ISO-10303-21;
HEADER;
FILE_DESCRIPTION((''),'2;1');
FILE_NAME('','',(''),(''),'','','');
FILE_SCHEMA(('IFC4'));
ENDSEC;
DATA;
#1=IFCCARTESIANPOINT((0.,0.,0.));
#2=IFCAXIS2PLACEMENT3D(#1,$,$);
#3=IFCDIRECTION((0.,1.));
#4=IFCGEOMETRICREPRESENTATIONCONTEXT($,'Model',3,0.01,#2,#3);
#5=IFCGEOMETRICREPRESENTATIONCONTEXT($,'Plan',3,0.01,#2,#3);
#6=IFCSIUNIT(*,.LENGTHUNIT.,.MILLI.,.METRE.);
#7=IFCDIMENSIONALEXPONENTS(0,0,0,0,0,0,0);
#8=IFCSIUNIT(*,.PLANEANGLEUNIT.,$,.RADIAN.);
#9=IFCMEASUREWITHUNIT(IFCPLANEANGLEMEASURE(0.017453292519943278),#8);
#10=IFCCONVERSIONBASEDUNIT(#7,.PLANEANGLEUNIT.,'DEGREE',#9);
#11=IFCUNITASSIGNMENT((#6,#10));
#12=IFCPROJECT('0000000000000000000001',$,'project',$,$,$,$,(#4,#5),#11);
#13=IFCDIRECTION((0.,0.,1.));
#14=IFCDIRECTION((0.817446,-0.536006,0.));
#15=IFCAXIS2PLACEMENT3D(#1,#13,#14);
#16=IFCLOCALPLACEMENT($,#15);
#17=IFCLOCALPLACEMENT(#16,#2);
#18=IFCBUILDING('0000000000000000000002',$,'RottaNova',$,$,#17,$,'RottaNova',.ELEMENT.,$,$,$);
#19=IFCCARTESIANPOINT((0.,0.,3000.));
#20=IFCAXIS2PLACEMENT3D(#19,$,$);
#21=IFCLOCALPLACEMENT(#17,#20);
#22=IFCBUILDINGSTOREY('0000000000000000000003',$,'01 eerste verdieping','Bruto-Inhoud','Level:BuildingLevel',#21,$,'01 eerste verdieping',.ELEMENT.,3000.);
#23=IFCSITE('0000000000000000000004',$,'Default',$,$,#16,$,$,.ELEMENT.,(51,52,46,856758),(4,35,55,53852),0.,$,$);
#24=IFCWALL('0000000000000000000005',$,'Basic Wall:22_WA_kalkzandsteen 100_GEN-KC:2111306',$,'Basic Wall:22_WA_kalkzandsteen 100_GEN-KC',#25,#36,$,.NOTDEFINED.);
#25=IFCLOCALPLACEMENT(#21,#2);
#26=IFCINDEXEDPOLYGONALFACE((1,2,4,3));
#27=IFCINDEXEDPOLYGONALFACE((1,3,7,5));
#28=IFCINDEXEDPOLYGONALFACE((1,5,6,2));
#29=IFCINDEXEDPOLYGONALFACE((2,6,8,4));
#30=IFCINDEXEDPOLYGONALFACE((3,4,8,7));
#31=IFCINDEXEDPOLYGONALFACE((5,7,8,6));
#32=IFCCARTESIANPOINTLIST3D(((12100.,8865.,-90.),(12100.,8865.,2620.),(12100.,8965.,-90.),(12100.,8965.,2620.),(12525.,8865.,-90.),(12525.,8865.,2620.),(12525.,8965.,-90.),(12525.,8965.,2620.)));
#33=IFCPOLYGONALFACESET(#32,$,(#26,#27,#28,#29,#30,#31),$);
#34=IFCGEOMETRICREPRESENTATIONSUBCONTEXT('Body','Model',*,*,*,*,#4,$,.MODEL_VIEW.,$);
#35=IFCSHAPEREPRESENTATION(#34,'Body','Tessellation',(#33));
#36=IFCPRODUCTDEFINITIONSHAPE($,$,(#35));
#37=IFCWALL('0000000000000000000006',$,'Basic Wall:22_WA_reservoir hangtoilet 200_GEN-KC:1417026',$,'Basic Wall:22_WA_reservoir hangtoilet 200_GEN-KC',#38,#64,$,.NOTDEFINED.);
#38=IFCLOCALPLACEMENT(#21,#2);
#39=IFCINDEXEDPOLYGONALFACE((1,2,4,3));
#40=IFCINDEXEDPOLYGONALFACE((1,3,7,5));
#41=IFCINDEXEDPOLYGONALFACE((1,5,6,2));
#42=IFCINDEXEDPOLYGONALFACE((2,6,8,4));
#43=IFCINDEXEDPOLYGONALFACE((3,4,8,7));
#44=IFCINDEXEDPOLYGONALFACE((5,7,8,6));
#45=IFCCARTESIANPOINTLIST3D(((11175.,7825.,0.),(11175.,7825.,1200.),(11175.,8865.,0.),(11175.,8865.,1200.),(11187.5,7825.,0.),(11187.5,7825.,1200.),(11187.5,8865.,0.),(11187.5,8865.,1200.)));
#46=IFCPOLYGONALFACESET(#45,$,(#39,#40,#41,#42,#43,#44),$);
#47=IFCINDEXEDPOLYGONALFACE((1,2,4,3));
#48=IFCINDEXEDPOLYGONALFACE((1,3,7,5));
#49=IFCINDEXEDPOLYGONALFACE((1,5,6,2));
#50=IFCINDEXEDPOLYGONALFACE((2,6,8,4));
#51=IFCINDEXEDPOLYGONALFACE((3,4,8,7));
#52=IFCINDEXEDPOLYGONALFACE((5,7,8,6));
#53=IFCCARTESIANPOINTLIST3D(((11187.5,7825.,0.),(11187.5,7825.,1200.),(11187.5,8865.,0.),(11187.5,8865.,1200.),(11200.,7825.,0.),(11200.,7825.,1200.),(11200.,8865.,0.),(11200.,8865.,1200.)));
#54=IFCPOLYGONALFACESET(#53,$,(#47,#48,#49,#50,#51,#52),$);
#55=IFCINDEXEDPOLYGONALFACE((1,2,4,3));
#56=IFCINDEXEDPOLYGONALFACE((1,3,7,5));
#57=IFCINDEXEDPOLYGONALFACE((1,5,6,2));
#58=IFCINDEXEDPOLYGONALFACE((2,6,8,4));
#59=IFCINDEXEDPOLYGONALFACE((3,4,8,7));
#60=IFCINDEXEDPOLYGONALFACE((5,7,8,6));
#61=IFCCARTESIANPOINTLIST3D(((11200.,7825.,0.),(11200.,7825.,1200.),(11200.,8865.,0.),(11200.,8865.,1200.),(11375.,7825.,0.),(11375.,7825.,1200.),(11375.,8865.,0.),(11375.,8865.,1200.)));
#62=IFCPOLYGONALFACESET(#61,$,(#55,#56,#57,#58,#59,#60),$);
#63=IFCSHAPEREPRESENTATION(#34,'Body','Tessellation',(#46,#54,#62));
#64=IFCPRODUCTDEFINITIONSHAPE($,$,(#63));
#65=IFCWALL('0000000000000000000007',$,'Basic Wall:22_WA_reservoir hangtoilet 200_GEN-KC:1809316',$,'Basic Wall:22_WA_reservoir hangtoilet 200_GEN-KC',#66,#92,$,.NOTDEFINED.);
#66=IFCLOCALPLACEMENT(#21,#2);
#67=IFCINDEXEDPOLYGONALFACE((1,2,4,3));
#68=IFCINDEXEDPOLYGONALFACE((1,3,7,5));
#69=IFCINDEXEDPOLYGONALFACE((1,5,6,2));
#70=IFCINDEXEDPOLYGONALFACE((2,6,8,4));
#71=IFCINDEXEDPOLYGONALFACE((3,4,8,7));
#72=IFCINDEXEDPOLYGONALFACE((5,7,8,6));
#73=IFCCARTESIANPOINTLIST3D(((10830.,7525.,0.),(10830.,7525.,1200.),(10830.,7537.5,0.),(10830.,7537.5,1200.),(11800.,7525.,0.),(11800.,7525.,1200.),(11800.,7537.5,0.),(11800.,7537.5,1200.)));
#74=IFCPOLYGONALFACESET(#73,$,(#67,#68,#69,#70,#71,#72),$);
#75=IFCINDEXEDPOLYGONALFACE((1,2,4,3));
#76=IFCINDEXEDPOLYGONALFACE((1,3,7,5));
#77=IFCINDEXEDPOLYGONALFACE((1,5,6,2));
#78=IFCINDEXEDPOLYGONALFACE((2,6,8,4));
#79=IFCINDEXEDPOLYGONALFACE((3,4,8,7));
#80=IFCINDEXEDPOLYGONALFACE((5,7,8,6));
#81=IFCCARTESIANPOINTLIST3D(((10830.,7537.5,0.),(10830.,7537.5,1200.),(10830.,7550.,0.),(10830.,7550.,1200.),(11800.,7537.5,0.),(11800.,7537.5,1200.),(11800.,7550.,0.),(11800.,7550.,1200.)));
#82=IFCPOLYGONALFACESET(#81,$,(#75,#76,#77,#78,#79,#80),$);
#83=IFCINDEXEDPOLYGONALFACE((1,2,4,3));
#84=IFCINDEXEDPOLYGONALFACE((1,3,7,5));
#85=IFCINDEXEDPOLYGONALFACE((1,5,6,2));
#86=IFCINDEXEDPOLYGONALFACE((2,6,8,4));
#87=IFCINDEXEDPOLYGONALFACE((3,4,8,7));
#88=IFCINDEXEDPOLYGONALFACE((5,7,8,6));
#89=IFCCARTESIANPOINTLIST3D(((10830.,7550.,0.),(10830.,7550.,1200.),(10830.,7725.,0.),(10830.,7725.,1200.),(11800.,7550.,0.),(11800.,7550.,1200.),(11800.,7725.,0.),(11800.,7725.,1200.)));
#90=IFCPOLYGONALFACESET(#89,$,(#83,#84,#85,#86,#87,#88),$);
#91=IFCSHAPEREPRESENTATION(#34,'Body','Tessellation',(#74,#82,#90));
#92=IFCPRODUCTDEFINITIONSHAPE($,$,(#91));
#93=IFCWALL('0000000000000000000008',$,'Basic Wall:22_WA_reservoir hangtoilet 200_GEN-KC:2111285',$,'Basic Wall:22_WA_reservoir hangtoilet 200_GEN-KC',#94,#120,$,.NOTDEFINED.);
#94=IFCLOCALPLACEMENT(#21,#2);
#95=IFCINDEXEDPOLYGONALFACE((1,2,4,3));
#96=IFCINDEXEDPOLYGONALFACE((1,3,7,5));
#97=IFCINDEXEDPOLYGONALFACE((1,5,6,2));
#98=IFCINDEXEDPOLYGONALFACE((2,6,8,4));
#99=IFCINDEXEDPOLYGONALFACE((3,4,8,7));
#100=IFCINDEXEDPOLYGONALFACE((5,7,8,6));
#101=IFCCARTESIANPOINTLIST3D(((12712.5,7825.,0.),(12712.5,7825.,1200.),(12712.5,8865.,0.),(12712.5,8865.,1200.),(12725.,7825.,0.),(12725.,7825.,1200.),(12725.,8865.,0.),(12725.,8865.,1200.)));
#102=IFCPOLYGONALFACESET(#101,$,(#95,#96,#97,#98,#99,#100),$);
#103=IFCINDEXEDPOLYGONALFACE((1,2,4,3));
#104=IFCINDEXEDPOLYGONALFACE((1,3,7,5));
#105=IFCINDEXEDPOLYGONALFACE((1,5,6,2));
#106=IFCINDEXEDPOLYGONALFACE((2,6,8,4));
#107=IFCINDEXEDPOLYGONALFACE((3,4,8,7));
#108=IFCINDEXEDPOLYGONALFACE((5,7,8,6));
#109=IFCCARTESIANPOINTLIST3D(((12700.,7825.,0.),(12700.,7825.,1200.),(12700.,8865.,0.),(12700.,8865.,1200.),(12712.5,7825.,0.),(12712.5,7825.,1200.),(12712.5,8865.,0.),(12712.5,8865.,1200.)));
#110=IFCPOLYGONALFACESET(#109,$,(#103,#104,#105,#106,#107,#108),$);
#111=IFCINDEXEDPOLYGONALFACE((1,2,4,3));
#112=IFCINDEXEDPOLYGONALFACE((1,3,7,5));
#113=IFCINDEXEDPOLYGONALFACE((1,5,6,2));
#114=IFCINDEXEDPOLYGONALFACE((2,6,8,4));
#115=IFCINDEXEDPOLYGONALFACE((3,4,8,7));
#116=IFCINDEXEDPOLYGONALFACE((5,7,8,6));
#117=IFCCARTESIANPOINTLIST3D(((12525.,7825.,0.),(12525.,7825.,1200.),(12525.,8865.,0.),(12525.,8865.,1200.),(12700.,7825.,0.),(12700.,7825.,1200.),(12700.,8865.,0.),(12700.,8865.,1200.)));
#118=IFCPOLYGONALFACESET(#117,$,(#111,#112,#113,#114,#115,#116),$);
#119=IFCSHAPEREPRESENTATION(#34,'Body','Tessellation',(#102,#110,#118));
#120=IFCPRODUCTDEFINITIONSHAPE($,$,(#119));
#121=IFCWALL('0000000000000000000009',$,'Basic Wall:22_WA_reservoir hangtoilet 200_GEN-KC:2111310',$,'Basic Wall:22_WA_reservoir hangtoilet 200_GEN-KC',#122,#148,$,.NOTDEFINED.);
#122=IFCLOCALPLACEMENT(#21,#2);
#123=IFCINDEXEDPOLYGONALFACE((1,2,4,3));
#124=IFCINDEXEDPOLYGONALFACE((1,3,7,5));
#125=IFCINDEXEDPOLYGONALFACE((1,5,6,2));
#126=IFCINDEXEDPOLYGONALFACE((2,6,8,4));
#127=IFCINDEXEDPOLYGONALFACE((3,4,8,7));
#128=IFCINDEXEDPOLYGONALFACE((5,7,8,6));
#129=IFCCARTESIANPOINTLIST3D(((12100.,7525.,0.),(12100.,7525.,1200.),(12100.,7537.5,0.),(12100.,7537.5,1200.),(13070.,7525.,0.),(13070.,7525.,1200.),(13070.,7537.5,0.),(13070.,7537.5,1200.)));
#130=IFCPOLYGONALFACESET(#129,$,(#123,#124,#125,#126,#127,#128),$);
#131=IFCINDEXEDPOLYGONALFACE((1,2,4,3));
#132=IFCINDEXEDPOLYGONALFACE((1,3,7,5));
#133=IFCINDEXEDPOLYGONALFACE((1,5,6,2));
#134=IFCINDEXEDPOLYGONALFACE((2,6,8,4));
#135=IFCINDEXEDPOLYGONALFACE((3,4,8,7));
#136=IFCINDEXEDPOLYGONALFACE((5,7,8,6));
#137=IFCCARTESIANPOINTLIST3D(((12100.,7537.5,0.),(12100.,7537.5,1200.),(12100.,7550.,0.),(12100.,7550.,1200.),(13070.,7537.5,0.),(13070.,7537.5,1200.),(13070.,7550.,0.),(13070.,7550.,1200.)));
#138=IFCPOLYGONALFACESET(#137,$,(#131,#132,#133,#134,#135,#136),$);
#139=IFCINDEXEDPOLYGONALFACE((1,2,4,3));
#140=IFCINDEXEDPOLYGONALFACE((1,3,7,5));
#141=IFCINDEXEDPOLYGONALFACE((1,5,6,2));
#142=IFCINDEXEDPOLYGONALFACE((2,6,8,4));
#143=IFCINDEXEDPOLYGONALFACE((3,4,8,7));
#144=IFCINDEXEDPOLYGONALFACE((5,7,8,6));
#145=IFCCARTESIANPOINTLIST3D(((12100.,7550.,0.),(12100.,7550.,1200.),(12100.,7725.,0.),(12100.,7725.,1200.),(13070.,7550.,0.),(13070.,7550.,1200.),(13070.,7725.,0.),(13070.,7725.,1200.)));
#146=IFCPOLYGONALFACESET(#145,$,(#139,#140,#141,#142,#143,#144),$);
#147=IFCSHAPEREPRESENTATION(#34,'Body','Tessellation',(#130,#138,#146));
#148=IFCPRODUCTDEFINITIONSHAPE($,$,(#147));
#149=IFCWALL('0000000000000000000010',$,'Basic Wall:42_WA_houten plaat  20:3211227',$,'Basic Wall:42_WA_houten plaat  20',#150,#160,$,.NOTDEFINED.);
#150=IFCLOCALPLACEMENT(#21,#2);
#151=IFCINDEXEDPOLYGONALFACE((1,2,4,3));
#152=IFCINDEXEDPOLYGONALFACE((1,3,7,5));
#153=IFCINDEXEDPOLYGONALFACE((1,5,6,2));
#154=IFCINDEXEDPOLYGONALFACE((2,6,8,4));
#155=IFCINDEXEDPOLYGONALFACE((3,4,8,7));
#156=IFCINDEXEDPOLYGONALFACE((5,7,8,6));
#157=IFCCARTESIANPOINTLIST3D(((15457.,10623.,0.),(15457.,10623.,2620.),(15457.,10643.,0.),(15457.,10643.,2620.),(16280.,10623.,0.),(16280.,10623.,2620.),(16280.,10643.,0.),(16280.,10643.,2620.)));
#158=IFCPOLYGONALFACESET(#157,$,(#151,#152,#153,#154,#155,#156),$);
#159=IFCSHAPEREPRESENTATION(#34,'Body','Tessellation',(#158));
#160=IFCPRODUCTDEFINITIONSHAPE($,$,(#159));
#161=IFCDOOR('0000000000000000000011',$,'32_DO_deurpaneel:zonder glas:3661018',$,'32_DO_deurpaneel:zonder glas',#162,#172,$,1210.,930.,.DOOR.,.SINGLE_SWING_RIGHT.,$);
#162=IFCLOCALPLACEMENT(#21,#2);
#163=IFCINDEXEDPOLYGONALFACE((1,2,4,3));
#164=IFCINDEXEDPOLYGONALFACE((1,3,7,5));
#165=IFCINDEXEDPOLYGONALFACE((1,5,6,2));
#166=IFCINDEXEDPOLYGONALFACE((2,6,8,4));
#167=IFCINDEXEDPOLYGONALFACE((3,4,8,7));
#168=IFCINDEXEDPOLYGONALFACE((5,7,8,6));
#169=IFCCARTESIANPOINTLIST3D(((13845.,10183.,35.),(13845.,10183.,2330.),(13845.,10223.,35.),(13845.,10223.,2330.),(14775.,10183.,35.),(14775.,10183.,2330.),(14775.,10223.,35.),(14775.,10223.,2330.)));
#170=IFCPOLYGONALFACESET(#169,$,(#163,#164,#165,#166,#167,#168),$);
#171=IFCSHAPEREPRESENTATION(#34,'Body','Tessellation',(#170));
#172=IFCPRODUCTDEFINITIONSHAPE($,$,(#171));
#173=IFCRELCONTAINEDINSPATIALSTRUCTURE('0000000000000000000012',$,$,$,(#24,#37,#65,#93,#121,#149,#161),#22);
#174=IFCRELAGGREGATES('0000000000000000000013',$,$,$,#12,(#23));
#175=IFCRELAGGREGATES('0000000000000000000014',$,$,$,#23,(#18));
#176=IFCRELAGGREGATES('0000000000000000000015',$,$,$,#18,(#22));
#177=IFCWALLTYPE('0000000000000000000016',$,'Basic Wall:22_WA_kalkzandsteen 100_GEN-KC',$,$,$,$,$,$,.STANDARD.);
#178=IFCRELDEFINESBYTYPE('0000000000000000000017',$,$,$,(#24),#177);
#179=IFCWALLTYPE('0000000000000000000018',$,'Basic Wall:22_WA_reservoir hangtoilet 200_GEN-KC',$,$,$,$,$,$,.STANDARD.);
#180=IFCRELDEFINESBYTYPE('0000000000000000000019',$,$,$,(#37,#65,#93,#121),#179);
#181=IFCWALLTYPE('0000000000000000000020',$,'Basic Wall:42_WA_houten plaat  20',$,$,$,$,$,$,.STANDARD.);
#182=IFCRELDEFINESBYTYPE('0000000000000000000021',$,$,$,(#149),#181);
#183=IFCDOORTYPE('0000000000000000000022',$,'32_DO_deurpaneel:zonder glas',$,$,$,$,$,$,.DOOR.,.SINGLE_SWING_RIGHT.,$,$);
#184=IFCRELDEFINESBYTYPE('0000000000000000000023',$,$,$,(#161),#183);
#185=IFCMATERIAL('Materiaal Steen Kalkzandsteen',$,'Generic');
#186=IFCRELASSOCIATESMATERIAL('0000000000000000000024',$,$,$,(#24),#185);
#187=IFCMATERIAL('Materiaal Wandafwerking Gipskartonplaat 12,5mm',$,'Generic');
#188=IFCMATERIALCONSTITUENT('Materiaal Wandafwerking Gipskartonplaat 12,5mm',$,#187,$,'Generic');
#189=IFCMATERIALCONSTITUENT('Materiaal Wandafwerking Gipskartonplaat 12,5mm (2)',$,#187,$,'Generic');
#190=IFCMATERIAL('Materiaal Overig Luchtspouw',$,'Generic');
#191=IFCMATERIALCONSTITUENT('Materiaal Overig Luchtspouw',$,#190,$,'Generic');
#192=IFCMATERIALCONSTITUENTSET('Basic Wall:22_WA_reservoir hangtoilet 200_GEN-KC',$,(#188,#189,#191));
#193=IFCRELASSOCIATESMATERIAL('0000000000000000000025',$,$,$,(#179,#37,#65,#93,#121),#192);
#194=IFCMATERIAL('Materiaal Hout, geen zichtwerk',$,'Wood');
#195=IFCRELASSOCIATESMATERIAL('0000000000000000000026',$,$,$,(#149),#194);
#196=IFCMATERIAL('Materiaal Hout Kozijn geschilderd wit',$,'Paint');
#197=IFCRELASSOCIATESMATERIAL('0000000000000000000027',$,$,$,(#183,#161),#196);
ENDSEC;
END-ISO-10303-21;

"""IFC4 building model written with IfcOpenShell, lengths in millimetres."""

from ifc_helpers import new_model, entity, si_unit, converted_unit, direction, frame, origin, place, context, subcontext, project, spatial, indexed_curve, outline, extrude, source, transform, mapped, material, constituent, constituent_set, type_object, type_shapes, element, save


model = new_model("IFC4")

# Units and contexts
model_context = context("Model", 3, precision=0.01, world=origin(), true_north=direction((0.0, 1.0)))
plan_context = context("Plan", 3, precision=0.01, world=origin(), true_north=direction((0.0, 1.0)))
body_context = subcontext(model_context, "Body", "Model", "MODEL_VIEW")
ifc_project = project(units=[si_unit("LENGTHUNIT", "METRE", prefix="MILLI"), converted_unit("PLANEANGLEUNIT", "DEGREE", entity("IfcPlaneAngleMeasure", 0.017453292519943278), si_unit("PLANEANGLEUNIT", "RADIAN"), dimensions=[0, 0, 0, 0, 0, 0, 0])], contexts=[model_context, plan_context])

# Site, building, storey
site_placement = place(None, frame((0.0, 0.0, 0.0), z_axis=(0.0, 0.0, 1.0), x_axis=(0.817446, -0.536006, 0.0)))
site = spatial("IfcSite", under=ifc_project, at=site_placement, Name="Default", CompositionType="ELEMENT", RefLatitude=(51, 52, 46, 856758), RefLongitude=(4, 35, 55, 53852), RefElevation=0.0)
building_placement = place(site_placement, origin())
building = spatial("IfcBuilding", under=site, at=building_placement, Name="RottaNova", LongName="RottaNova", CompositionType="ELEMENT")
storey_placement = place(building_placement, frame((0.0, 0.0, 3000.0)))
storey = spatial("IfcBuildingStorey", under=building, at=storey_placement, Name="01 eerste verdieping", Description="Bruto-Inhoud", ObjectType="Level:BuildingLevel", LongName="01 eerste verdieping", CompositionType="ELEMENT", Elevation=3000.0)

# Walls
ifc_material_1 = material(Name="Materiaal Steen Kalkzandsteen", Category="Generic")
wall_type_1 = type_object("IfcWallType", Name="Basic Wall:22_WA_kalkzandsteen 100_GEN-KC", PredefinedType="STANDARD")
wall_1_placement = place(storey_placement, frame((12100.0, 8915.0, -90.0)))
element("IfcWall", 1, at=wall_1_placement, inside=storey, type_object=wall_type_1, material=ifc_material_1, Name="Basic Wall:22_WA_kalkzandsteen 100_GEN-KC:2111306", ObjectType="Basic Wall:22_WA_kalkzandsteen 100_GEN-KC", PredefinedType="NOTDEFINED", context=body_context, shape_type="SweptSolid", body=[
    extrude(outline(indexed_curve([(425.0, 50.0), (0.0, 50.0), (0.0, -50.0), (425.0, -50.0), (425.0, 50.0)], self_intersect=False)), origin(), (0.0, 0.0, 1.0), 2710.0),
])
ifc_material_2 = material(Name="Materiaal Wandafwerking Gipskartonplaat 12,5mm", Category="Generic")
ifc_constituent_1 = constituent(ifc_material_2, Name="Materiaal Wandafwerking Gipskartonplaat 12,5mm", Category="Generic")
ifc_constituent_2 = constituent(ifc_material_2, Name="Materiaal Wandafwerking Gipskartonplaat 12,5mm (2)", Category="Generic")
ifc_material_3 = material(Name="Materiaal Overig Luchtspouw", Category="Generic")
ifc_constituent_3 = constituent(ifc_material_3, Name="Materiaal Overig Luchtspouw", Category="Generic")
ifc_constituent_set = constituent_set(constituents=[ifc_constituent_1, ifc_constituent_2, ifc_constituent_3], Name="Basic Wall:22_WA_reservoir hangtoilet 200_GEN-KC")
wall_type_2 = type_object("IfcWallType", Name="Basic Wall:22_WA_reservoir hangtoilet 200_GEN-KC", PredefinedType="STANDARD", material=ifc_constituent_set)
wall_2_placement = place(storey_placement, frame((11275.0, 8865.0, 0.0), z_axis=(0.0, 0.0, 1.0), x_axis=(0.0, -1.0, 0.0)))
element("IfcWall", 2, at=wall_2_placement, inside=storey, type_object=wall_type_2, material=ifc_constituent_set, Name="Basic Wall:22_WA_reservoir hangtoilet 200_GEN-KC:1417026", ObjectType="Basic Wall:22_WA_reservoir hangtoilet 200_GEN-KC", PredefinedType="NOTDEFINED", context=body_context, shape_type="SweptSolid", body=[
    extrude(outline(indexed_curve([(-6.2, -520.0), (6.3, -520.0), (6.2, 520.0), (-6.3, 520.0), (-6.2, -520.0)], self_intersect=False)), frame((520.0, -93.7, 0.0), z_axis=(0.0, 0.0, 1.0), x_axis=(0.0, 1.0, 0.0)), (0.0, 0.0, 1.0), 1200.0),
    extrude(outline(indexed_curve([(-520.0, -6.2), (520.0, -6.2), (520.0, 6.2), (-520.0, 6.2), (-520.0, -6.2)], self_intersect=False)), frame((520.0, -81.2, 0.0)), (0.0, 0.0, 1.0), 1200.0),
    extrude(outline(indexed_curve([(-87.5, -520.0), (87.5, -520.0), (87.5, 520.0), (-87.5, 520.0), (-87.5, -520.0)], self_intersect=False)), frame((520.0, 12.5, 0.0), z_axis=(0.0, 0.0, 1.0), x_axis=(0.0, -1.0, 0.0)), (0.0, 0.0, 1.0), 1200.0),
])
wall_3_placement = place(storey_placement, frame((10830.0, 7625.0, 0.0)))
element("IfcWall", 3, at=wall_3_placement, inside=storey, type_object=wall_type_2, material=ifc_constituent_set, Name="Basic Wall:22_WA_reservoir hangtoilet 200_GEN-KC:1809316", ObjectType="Basic Wall:22_WA_reservoir hangtoilet 200_GEN-KC", PredefinedType="NOTDEFINED", context=body_context, shape_type="SweptSolid", body=[
    extrude(outline(indexed_curve([(-6.2, -485.0), (6.3, -485.0), (6.2, 485.0), (-6.3, 485.0), (-6.2, -485.0)], self_intersect=False)), frame((485.0, -93.8, 0.0), z_axis=(0.0, 0.0, 1.0), x_axis=(0.0, 1.0, 0.0)), (0.0, 0.0, 1.0), 1200.0),
    extrude(outline(indexed_curve([(-485.0, -6.3), (485.0, -6.3), (485.0, 6.2), (-485.0, 6.2), (-485.0, -6.3)], self_intersect=False)), frame((485.0, -81.3, 0.0)), (0.0, 0.0, 1.0), 1200.0),
    extrude(outline(indexed_curve([(-87.5, -485.0), (87.5, -485.0), (87.5, 485.0), (-87.5, 485.0), (-87.5, -485.0)], self_intersect=False)), frame((485.0, 12.5, 0.0), z_axis=(0.0, 0.0, 1.0), x_axis=(0.0, -1.0, 0.0)), (0.0, 0.0, 1.0), 1200.0),
])
wall_4_placement = place(storey_placement, frame((12625.0, 8865.0, 0.0), z_axis=(0.0, 0.0, 1.0), x_axis=(0.0, -1.0, 0.0)))
element("IfcWall", 4, at=wall_4_placement, inside=storey, type_object=wall_type_2, material=ifc_constituent_set, Name="Basic Wall:22_WA_reservoir hangtoilet 200_GEN-KC:2111285", ObjectType="Basic Wall:22_WA_reservoir hangtoilet 200_GEN-KC", PredefinedType="NOTDEFINED", context=body_context, shape_type="SweptSolid", body=[
    extrude(outline(indexed_curve([(-6.3, -520.0), (6.2, -520.0), (6.3, 520.0), (-6.2, 520.0), (-6.3, -520.0)], self_intersect=False)), frame((520.0, 93.8, 0.0), z_axis=(0.0, 0.0, 1.0), x_axis=(0.0, -1.0, 0.0)), (0.0, 0.0, 1.0), 1200.0),
    extrude(outline(indexed_curve([(-520.0, -6.2), (520.0, -6.2), (520.0, 6.2), (-520.0, 6.2), (-520.0, -6.2)], self_intersect=False)), frame((520.0, 81.2, 0.0)), (0.0, 0.0, 1.0), 1200.0),
    extrude(outline(indexed_curve([(-87.5, -520.0), (87.5, -520.0), (87.5, 520.0), (-87.5, 520.0), (-87.5, -520.0)], self_intersect=False)), frame((520.0, -12.5, 0.0), z_axis=(0.0, 0.0, 1.0), x_axis=(0.0, 1.0, 0.0)), (0.0, 0.0, 1.0), 1200.0),
])
wall_5_placement = place(storey_placement, frame((13070.0, 7625.0, 0.0), z_axis=(0.0, 0.0, 1.0), x_axis=(-1.0, 0.0, 0.0)))
element("IfcWall", 5, at=wall_5_placement, inside=storey, type_object=wall_type_2, material=ifc_constituent_set, Name="Basic Wall:22_WA_reservoir hangtoilet 200_GEN-KC:2111310", ObjectType="Basic Wall:22_WA_reservoir hangtoilet 200_GEN-KC", PredefinedType="NOTDEFINED", context=body_context, shape_type="SweptSolid", body=[
    extrude(outline(indexed_curve([(-6.3, -485.0), (6.2, -485.0), (6.3, 485.0), (-6.2, 485.0), (-6.3, -485.0)], self_intersect=False)), frame((485.0, 93.8, 0.0), z_axis=(0.0, 0.0, 1.0), x_axis=(0.0, -1.0, 0.0)), (0.0, 0.0, 1.0), 1200.0),
    extrude(outline(indexed_curve([(-485.0, -6.2), (485.0, -6.2), (485.0, 6.3), (-485.0, 6.3), (-485.0, -6.2)], self_intersect=False)), frame((485.0, 81.2, 0.0)), (0.0, 0.0, 1.0), 1200.0),
    extrude(outline(indexed_curve([(-87.5, -485.0), (87.5, -485.0), (87.5, 485.0), (-87.5, 485.0), (-87.5, -485.0)], self_intersect=False)), frame((485.0, -12.5, 0.0), z_axis=(0.0, 0.0, 1.0), x_axis=(0.0, 1.0, 0.0)), (0.0, 0.0, 1.0), 1200.0),
])
ifc_material_4 = material(Name="Materiaal Hout, geen zichtwerk", Category="Wood")
wall_type_3 = type_object("IfcWallType", Name="Basic Wall:42_WA_houten plaat  20", PredefinedType="STANDARD")
wall_6_placement = place(storey_placement, frame((16280.0, 10633.0, 0.0), z_axis=(0.0, 0.0, 1.0), x_axis=(-1.0, 0.0, 0.0)))
element("IfcWall", 6, at=wall_6_placement, inside=storey, type_object=wall_type_3, material=ifc_material_4, Name="Basic Wall:42_WA_houten plaat  20:3211227", ObjectType="Basic Wall:42_WA_houten plaat  20", PredefinedType="NOTDEFINED", context=body_context, shape_type="SweptSolid", body=[
    extrude(outline(indexed_curve([(823.0, 10.0), (0.0, 10.0), (0.0, -10.0), (823.0, -10.0), (823.0, 10.0)], self_intersect=False)), origin(), (0.0, 0.0, 1.0), 2620.0),
])

# Door
ifc_material_5 = material(Name="Materiaal Hout Kozijn geschilderd wit", Category="Paint")
door_type = type_object("IfcDoorType", Name="32_DO_deurpaneel:zonder glas", OperationType="SINGLE_SWING_RIGHT", PredefinedType="DOOR", material=ifc_material_5)
shared_shape_1 = source(origin(), body_context, "Body", "SweptSolid", [
    extrude(outline(indexed_curve([(-1147.5, -20.0), (1147.5, -20.0), (1147.5, 20.0), (-1147.5, 20.0), (-1147.5, -20.0)], self_intersect=False)), frame((-465.0, 20.0, 1182.5), z_axis=(1.0, 0.0, 0.0), x_axis=(0.0, 0.0, 1.0)), (0.0, 0.0, 1.0), 930.0),
])
type_shapes(door_type, [shared_shape_1])
door_placement = place(storey_placement, frame((14310.0, 10223.0, 0.0), z_axis=(0.0, 0.0, 1.0), x_axis=(-1.0, 0.0, 0.0)))
element("IfcDoor", 7, at=door_placement, inside=storey, type_object=door_type, material=ifc_material_5, Name="32_DO_deurpaneel:zonder glas:3661018", ObjectType="32_DO_deurpaneel:zonder glas", OperationType="SINGLE_SWING_RIGHT", OverallHeight=1210.0, OverallWidth=930.0, PredefinedType="DOOR", context=body_context, shape_type="MappedRepresentation", body=[
    mapped(shared_shape_1, transform((0.0, 0.0, 0.0), scale=1.0)),
])

save(model, "model.ifc")
